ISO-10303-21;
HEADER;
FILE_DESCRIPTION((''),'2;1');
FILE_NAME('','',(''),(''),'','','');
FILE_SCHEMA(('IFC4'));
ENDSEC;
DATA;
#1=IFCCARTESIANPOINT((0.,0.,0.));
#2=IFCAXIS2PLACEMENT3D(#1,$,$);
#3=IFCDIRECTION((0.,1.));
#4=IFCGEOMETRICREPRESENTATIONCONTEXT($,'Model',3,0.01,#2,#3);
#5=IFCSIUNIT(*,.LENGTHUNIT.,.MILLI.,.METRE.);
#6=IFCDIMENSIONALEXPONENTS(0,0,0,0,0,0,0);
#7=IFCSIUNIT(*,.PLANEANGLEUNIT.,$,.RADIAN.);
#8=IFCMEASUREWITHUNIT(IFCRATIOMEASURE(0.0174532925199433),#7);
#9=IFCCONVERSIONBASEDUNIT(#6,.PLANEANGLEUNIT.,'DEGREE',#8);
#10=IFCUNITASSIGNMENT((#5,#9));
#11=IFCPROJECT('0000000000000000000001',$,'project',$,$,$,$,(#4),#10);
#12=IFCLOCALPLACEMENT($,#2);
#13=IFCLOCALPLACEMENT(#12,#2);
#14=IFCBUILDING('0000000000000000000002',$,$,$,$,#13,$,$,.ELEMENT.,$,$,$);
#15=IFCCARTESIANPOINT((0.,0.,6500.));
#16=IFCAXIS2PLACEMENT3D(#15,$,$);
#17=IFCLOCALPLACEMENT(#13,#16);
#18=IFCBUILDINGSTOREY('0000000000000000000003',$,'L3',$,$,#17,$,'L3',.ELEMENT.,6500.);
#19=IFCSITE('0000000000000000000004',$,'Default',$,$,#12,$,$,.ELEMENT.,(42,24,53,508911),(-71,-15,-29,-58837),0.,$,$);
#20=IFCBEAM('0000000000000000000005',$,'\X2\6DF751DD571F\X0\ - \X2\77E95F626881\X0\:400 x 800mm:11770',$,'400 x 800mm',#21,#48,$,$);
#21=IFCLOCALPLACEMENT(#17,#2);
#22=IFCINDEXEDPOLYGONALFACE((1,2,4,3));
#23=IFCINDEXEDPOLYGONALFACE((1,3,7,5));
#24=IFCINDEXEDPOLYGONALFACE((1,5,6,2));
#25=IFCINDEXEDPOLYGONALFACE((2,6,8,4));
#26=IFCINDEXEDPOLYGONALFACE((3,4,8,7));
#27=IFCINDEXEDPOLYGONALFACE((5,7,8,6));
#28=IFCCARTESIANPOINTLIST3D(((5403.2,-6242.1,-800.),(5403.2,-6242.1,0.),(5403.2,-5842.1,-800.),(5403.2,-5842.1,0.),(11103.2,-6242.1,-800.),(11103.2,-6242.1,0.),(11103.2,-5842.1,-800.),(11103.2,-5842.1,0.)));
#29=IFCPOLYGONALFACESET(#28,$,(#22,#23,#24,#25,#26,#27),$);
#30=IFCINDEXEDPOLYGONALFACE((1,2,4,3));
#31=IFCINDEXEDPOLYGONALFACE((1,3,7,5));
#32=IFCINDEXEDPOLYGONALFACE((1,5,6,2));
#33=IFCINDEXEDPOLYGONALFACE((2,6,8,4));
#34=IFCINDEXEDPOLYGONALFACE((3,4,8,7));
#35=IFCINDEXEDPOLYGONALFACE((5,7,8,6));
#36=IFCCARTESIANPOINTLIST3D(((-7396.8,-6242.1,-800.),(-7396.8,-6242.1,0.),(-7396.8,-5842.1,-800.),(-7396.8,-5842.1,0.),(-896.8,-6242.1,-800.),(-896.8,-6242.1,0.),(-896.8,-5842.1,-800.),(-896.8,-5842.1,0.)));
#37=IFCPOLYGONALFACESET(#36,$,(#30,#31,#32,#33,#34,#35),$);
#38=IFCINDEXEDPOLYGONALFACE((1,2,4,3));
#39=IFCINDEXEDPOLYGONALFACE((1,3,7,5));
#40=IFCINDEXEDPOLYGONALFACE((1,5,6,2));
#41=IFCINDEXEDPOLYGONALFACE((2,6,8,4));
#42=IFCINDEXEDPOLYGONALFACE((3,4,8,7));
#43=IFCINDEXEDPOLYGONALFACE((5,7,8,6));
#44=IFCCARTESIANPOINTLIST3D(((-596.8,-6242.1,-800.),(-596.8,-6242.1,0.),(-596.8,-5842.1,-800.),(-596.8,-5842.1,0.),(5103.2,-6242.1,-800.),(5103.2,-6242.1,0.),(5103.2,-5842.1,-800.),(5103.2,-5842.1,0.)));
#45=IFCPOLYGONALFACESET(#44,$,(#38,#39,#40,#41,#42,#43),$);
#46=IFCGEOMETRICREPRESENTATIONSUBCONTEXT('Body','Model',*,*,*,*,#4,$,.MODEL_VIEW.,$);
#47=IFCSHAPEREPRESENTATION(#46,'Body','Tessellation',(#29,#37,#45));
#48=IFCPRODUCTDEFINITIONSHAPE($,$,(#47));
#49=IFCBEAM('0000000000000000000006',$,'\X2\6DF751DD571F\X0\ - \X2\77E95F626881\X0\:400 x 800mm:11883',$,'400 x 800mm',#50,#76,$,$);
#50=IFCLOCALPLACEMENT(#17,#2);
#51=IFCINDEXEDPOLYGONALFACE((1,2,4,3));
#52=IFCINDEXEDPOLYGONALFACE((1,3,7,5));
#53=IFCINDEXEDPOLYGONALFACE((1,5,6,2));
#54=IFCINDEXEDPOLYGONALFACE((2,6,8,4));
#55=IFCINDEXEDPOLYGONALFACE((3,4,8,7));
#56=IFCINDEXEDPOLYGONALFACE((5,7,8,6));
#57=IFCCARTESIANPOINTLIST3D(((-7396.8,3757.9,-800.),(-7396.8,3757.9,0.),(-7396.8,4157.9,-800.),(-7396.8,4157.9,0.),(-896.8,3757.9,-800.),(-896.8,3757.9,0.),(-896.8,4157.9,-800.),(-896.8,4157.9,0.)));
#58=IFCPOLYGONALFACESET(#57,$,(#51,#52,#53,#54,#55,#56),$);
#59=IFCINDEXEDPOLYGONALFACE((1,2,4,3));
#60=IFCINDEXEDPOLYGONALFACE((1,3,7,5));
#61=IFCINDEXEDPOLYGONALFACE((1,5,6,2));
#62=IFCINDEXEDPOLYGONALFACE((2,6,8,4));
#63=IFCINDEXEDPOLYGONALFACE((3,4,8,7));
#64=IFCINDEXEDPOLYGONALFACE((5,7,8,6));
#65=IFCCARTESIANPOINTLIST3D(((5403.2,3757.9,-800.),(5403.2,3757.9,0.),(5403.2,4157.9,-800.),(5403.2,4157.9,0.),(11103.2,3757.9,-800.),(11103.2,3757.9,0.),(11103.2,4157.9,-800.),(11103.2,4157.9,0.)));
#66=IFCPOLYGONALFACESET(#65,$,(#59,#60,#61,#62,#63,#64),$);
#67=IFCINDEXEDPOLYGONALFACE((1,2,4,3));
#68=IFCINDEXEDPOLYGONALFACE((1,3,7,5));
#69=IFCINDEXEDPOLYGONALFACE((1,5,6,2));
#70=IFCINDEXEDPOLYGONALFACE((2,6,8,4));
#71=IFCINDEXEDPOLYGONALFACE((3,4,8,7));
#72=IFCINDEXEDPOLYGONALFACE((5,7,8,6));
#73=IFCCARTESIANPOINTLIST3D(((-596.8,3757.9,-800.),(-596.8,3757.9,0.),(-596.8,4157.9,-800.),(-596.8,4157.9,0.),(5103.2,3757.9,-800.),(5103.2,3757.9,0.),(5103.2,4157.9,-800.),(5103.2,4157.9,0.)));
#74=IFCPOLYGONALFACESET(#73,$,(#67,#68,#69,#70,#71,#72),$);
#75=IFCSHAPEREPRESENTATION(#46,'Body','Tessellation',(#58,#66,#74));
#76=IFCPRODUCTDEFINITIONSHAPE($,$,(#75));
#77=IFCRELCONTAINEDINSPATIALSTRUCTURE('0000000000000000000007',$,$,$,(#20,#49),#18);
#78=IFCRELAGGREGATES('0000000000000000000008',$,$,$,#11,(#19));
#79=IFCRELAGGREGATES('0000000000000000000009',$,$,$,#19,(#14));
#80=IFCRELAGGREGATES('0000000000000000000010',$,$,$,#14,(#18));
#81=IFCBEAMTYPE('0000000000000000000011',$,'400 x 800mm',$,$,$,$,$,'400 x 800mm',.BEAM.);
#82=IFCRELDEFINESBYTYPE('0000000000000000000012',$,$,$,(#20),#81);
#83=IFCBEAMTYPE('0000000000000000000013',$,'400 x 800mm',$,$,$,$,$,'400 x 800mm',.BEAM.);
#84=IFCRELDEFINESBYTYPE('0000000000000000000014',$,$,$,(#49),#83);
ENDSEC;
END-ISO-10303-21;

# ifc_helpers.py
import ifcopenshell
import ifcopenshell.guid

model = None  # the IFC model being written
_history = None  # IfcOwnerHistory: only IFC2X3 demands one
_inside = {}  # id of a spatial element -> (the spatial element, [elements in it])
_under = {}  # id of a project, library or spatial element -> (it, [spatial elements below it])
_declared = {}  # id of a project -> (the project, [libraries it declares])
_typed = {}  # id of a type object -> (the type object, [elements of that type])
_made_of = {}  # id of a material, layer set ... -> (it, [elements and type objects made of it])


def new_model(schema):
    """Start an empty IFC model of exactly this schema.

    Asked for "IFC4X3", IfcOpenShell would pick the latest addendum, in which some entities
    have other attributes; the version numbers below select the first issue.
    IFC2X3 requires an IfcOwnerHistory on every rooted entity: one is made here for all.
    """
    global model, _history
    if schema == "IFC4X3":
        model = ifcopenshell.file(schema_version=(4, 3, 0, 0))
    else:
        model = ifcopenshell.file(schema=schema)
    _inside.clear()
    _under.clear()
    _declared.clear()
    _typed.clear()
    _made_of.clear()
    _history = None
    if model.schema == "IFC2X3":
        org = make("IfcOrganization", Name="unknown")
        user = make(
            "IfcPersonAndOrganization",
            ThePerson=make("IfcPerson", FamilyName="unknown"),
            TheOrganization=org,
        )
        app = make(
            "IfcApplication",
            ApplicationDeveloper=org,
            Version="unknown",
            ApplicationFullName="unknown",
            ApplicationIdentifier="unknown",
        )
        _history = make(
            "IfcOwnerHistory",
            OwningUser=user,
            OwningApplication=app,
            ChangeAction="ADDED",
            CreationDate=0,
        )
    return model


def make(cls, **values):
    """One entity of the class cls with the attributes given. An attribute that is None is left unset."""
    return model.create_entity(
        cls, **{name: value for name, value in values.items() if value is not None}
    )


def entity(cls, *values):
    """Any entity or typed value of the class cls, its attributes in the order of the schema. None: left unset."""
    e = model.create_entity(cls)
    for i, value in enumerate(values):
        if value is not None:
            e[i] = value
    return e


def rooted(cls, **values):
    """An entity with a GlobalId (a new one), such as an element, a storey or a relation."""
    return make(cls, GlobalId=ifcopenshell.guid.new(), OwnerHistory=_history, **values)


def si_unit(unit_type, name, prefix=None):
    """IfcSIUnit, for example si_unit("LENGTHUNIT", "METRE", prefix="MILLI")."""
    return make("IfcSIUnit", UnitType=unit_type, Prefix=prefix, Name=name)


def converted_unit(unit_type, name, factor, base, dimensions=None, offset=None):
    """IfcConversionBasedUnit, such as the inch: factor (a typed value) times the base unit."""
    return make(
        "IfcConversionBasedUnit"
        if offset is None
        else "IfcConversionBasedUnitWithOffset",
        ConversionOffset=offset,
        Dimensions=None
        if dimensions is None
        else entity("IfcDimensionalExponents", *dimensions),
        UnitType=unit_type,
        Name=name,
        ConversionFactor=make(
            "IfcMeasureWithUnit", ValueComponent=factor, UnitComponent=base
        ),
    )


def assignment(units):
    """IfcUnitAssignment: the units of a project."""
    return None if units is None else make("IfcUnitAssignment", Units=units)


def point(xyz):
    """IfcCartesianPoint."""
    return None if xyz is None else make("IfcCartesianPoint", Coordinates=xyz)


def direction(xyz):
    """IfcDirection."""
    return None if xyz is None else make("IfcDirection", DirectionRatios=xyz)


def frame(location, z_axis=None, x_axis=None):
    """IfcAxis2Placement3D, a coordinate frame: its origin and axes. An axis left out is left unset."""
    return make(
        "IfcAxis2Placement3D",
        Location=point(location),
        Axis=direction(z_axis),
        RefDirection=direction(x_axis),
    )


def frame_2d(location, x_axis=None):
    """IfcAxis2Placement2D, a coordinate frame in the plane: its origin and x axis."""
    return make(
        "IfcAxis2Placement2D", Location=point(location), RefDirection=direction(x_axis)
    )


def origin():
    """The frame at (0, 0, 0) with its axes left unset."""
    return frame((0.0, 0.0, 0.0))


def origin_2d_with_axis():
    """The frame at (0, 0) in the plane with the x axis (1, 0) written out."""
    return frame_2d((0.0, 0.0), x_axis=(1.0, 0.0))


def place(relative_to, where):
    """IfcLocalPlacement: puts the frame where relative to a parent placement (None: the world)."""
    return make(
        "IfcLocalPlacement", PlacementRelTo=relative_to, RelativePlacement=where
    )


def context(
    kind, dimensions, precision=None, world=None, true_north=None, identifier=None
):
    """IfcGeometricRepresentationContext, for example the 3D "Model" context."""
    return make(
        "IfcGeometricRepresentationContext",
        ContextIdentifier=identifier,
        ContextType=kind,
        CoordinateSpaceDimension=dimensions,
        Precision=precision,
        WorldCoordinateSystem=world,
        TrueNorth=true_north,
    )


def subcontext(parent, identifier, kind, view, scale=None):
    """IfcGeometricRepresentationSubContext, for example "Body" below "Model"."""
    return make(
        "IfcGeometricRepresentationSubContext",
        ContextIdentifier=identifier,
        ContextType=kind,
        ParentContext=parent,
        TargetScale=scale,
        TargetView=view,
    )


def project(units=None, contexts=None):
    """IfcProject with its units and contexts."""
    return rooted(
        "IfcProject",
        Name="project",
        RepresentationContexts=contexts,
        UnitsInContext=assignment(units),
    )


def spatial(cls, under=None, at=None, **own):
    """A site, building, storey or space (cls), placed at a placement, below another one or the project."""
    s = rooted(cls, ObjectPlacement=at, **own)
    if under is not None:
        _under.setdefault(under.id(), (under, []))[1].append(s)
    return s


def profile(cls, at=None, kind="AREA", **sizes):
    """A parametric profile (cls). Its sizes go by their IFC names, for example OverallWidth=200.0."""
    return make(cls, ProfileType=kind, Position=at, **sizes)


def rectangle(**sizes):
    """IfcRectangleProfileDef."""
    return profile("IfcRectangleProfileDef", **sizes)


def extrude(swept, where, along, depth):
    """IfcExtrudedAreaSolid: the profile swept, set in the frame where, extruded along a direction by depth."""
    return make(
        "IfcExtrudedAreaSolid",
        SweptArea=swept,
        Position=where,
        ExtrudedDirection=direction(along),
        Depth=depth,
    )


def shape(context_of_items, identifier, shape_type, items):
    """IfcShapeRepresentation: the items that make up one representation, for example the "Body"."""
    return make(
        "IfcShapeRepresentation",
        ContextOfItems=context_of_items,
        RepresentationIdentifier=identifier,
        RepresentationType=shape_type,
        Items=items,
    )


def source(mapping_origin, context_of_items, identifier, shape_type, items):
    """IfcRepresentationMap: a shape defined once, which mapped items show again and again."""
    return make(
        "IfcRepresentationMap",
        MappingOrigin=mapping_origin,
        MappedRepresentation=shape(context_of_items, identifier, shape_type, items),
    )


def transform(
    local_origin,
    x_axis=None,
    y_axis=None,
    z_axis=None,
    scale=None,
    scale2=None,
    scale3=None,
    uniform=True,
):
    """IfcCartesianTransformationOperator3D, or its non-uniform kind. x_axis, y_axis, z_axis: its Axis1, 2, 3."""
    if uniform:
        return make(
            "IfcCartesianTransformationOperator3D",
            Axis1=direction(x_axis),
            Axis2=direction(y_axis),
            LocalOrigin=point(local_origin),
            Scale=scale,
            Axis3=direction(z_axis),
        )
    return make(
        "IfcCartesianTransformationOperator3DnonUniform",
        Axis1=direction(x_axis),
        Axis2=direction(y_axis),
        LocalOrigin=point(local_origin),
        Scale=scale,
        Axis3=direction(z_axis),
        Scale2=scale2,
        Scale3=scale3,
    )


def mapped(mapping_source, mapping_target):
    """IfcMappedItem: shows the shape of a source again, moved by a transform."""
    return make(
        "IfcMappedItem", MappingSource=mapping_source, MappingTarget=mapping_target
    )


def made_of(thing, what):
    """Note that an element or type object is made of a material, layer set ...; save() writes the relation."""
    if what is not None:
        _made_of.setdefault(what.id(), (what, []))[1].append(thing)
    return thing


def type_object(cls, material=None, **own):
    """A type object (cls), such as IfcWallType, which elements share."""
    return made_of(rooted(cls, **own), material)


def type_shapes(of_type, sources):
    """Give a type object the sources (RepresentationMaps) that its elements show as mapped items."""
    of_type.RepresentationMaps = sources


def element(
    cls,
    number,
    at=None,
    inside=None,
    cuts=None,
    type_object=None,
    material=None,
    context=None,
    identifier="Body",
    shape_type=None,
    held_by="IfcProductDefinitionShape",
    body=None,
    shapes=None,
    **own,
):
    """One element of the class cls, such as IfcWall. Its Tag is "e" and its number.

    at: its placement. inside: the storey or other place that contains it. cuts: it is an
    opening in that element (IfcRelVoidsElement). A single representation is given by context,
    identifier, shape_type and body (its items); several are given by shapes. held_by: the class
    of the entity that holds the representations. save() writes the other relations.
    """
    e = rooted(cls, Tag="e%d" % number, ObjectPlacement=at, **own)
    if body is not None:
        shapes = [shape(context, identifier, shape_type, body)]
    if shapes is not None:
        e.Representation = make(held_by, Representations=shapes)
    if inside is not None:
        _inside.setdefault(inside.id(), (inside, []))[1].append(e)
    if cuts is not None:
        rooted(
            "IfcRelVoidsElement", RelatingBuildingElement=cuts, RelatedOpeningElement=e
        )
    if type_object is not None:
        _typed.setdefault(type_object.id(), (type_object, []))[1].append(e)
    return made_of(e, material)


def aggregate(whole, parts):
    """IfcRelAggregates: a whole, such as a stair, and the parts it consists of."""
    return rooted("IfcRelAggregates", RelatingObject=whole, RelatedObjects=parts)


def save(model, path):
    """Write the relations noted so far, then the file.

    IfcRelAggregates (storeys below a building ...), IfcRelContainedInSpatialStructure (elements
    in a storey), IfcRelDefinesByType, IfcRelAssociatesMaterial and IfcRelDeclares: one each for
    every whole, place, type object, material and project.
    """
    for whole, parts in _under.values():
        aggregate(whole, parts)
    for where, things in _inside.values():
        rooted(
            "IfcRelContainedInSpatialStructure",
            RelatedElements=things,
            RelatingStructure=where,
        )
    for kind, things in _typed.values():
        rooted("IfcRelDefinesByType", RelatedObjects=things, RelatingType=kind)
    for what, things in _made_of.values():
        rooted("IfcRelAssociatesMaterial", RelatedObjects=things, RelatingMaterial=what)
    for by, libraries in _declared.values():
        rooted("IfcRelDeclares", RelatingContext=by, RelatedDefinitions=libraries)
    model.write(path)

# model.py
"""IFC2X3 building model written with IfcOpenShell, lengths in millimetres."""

from ifc_helpers import new_model, entity, si_unit, converted_unit, direction, frame, frame_2d, origin, origin_2d_with_axis, place, context, subcontext, project, spatial, rectangle, extrude, source, transform, mapped, type_object, type_shapes, element, save


model = new_model("IFC2X3")

# Units and contexts
model_context = context("Model", 3, precision=0.01, world=origin(), true_north=direction((0.0, 1.0)))
body_context = subcontext(model_context, "Body", "Model", "MODEL_VIEW")
ifc_project = project(units=[si_unit("LENGTHUNIT", "METRE", prefix="MILLI"), converted_unit("PLANEANGLEUNIT", "DEGREE", entity("IfcRatioMeasure", 0.0174532925199433), si_unit("PLANEANGLEUNIT", "RADIAN"), dimensions=[0, 0, 0, 0, 0, 0, 0])], contexts=[model_context])

# Site, building, storey
site_placement = place(None, origin())
site = spatial("IfcSite", under=ifc_project, at=site_placement, Name="Default", CompositionType="ELEMENT", RefLatitude=(42, 24, 53, 508911), RefLongitude=(-71, -15, -29, -58837), RefElevation=0.0)
building_placement = place(site_placement, origin())
building = spatial("IfcBuilding", under=site, at=building_placement, CompositionType="ELEMENT")
storey_placement = place(building_placement, frame((0.0, 0.0, 6500.0)))
storey = spatial("IfcBuildingStorey", under=building, at=storey_placement, Name="L3", LongName="L3", CompositionType="ELEMENT", Elevation=6500.0)

# Beams
beam_type_1 = type_object("IfcBeamType", Name="400 x 800mm", ElementType="400 x 800mm", PredefinedType="BEAM")
shared_shape_1 = source(origin(), body_context, "Body", "SweptSolid", [
    extrude(rectangle(XDim=5700.0, YDim=400.0, at=frame_2d((0.0, 0.0), x_axis=(1.0, 0.0))), frame((8253.2, -6042.1, 5700.0), z_axis=(0.0, 0.0, 1.0), x_axis=(-1.0, 0.0, 0.0)), (0.0, 0.0, 1.0), 800.0),
    extrude(rectangle(XDim=6500.0, YDim=400.0, at=frame_2d((0.0, 0.0), x_axis=(1.0, 0.0))), frame((-4146.8, -6042.1, 5700.0)), (0.0, 0.0, 1.0), 800.0),
    extrude(rectangle(XDim=5700.0, YDim=400.0, at=origin_2d_with_axis()), frame((2253.2, -6042.1, 5700.0)), (0.0, 0.0, 1.0), 800.0),
])
type_shapes(beam_type_1, [shared_shape_1])
beam_1_placement = place(storey_placement, frame((0.0, 0.0, -6500.0)))
element("IfcBeam", 1, at=beam_1_placement, inside=storey, type_object=beam_type_1, Name="混凝土 - 矩形梁:400 x 800mm:11770", ObjectType="400 x 800mm", context=body_context, shape_type="MappedRepresentation", body=[
    mapped(shared_shape_1, transform((0.0, 0.0, 0.0), scale=1.0)),
])
beam_type_2 = type_object("IfcBeamType", Name="400 x 800mm", ElementType="400 x 800mm", PredefinedType="BEAM")
shared_shape_2 = source(origin(), body_context, "Body", "SweptSolid", [
    extrude(rectangle(XDim=6500.0, YDim=400.0, at=frame_2d((0.0, 0.0), x_axis=(1.0, 0.0))), frame((-4146.8, 3957.9, 5700.0)), (0.0, 0.0, 1.0), 800.0),
    extrude(rectangle(XDim=5700.0, YDim=400.0, at=frame_2d((0.0, 0.0), x_axis=(1.0, 0.0))), frame((8253.2, 3957.9, 5700.0)), (0.0, 0.0, 1.0), 800.0),
    extrude(rectangle(XDim=5700.0, YDim=400.0, at=origin_2d_with_axis()), frame((2253.2, 3957.9, 5700.0), z_axis=(0.0, 0.0, 1.0), x_axis=(-1.0, 0.0, 0.0)), (0.0, 0.0, 1.0), 800.0),
])
type_shapes(beam_type_2, [shared_shape_2])
beam_2_placement = place(storey_placement, frame((0.0, 0.0, -6500.0)))
element("IfcBeam", 2, at=beam_2_placement, inside=storey, type_object=beam_type_2, Name="混凝土 - 矩形梁:400 x 800mm:11883", ObjectType="400 x 800mm", context=body_context, shape_type="MappedRepresentation", body=[
    mapped(shared_shape_2, transform((0.0, 0.0, 0.0), scale=1.0)),
])

save(model, "model.ifc")
